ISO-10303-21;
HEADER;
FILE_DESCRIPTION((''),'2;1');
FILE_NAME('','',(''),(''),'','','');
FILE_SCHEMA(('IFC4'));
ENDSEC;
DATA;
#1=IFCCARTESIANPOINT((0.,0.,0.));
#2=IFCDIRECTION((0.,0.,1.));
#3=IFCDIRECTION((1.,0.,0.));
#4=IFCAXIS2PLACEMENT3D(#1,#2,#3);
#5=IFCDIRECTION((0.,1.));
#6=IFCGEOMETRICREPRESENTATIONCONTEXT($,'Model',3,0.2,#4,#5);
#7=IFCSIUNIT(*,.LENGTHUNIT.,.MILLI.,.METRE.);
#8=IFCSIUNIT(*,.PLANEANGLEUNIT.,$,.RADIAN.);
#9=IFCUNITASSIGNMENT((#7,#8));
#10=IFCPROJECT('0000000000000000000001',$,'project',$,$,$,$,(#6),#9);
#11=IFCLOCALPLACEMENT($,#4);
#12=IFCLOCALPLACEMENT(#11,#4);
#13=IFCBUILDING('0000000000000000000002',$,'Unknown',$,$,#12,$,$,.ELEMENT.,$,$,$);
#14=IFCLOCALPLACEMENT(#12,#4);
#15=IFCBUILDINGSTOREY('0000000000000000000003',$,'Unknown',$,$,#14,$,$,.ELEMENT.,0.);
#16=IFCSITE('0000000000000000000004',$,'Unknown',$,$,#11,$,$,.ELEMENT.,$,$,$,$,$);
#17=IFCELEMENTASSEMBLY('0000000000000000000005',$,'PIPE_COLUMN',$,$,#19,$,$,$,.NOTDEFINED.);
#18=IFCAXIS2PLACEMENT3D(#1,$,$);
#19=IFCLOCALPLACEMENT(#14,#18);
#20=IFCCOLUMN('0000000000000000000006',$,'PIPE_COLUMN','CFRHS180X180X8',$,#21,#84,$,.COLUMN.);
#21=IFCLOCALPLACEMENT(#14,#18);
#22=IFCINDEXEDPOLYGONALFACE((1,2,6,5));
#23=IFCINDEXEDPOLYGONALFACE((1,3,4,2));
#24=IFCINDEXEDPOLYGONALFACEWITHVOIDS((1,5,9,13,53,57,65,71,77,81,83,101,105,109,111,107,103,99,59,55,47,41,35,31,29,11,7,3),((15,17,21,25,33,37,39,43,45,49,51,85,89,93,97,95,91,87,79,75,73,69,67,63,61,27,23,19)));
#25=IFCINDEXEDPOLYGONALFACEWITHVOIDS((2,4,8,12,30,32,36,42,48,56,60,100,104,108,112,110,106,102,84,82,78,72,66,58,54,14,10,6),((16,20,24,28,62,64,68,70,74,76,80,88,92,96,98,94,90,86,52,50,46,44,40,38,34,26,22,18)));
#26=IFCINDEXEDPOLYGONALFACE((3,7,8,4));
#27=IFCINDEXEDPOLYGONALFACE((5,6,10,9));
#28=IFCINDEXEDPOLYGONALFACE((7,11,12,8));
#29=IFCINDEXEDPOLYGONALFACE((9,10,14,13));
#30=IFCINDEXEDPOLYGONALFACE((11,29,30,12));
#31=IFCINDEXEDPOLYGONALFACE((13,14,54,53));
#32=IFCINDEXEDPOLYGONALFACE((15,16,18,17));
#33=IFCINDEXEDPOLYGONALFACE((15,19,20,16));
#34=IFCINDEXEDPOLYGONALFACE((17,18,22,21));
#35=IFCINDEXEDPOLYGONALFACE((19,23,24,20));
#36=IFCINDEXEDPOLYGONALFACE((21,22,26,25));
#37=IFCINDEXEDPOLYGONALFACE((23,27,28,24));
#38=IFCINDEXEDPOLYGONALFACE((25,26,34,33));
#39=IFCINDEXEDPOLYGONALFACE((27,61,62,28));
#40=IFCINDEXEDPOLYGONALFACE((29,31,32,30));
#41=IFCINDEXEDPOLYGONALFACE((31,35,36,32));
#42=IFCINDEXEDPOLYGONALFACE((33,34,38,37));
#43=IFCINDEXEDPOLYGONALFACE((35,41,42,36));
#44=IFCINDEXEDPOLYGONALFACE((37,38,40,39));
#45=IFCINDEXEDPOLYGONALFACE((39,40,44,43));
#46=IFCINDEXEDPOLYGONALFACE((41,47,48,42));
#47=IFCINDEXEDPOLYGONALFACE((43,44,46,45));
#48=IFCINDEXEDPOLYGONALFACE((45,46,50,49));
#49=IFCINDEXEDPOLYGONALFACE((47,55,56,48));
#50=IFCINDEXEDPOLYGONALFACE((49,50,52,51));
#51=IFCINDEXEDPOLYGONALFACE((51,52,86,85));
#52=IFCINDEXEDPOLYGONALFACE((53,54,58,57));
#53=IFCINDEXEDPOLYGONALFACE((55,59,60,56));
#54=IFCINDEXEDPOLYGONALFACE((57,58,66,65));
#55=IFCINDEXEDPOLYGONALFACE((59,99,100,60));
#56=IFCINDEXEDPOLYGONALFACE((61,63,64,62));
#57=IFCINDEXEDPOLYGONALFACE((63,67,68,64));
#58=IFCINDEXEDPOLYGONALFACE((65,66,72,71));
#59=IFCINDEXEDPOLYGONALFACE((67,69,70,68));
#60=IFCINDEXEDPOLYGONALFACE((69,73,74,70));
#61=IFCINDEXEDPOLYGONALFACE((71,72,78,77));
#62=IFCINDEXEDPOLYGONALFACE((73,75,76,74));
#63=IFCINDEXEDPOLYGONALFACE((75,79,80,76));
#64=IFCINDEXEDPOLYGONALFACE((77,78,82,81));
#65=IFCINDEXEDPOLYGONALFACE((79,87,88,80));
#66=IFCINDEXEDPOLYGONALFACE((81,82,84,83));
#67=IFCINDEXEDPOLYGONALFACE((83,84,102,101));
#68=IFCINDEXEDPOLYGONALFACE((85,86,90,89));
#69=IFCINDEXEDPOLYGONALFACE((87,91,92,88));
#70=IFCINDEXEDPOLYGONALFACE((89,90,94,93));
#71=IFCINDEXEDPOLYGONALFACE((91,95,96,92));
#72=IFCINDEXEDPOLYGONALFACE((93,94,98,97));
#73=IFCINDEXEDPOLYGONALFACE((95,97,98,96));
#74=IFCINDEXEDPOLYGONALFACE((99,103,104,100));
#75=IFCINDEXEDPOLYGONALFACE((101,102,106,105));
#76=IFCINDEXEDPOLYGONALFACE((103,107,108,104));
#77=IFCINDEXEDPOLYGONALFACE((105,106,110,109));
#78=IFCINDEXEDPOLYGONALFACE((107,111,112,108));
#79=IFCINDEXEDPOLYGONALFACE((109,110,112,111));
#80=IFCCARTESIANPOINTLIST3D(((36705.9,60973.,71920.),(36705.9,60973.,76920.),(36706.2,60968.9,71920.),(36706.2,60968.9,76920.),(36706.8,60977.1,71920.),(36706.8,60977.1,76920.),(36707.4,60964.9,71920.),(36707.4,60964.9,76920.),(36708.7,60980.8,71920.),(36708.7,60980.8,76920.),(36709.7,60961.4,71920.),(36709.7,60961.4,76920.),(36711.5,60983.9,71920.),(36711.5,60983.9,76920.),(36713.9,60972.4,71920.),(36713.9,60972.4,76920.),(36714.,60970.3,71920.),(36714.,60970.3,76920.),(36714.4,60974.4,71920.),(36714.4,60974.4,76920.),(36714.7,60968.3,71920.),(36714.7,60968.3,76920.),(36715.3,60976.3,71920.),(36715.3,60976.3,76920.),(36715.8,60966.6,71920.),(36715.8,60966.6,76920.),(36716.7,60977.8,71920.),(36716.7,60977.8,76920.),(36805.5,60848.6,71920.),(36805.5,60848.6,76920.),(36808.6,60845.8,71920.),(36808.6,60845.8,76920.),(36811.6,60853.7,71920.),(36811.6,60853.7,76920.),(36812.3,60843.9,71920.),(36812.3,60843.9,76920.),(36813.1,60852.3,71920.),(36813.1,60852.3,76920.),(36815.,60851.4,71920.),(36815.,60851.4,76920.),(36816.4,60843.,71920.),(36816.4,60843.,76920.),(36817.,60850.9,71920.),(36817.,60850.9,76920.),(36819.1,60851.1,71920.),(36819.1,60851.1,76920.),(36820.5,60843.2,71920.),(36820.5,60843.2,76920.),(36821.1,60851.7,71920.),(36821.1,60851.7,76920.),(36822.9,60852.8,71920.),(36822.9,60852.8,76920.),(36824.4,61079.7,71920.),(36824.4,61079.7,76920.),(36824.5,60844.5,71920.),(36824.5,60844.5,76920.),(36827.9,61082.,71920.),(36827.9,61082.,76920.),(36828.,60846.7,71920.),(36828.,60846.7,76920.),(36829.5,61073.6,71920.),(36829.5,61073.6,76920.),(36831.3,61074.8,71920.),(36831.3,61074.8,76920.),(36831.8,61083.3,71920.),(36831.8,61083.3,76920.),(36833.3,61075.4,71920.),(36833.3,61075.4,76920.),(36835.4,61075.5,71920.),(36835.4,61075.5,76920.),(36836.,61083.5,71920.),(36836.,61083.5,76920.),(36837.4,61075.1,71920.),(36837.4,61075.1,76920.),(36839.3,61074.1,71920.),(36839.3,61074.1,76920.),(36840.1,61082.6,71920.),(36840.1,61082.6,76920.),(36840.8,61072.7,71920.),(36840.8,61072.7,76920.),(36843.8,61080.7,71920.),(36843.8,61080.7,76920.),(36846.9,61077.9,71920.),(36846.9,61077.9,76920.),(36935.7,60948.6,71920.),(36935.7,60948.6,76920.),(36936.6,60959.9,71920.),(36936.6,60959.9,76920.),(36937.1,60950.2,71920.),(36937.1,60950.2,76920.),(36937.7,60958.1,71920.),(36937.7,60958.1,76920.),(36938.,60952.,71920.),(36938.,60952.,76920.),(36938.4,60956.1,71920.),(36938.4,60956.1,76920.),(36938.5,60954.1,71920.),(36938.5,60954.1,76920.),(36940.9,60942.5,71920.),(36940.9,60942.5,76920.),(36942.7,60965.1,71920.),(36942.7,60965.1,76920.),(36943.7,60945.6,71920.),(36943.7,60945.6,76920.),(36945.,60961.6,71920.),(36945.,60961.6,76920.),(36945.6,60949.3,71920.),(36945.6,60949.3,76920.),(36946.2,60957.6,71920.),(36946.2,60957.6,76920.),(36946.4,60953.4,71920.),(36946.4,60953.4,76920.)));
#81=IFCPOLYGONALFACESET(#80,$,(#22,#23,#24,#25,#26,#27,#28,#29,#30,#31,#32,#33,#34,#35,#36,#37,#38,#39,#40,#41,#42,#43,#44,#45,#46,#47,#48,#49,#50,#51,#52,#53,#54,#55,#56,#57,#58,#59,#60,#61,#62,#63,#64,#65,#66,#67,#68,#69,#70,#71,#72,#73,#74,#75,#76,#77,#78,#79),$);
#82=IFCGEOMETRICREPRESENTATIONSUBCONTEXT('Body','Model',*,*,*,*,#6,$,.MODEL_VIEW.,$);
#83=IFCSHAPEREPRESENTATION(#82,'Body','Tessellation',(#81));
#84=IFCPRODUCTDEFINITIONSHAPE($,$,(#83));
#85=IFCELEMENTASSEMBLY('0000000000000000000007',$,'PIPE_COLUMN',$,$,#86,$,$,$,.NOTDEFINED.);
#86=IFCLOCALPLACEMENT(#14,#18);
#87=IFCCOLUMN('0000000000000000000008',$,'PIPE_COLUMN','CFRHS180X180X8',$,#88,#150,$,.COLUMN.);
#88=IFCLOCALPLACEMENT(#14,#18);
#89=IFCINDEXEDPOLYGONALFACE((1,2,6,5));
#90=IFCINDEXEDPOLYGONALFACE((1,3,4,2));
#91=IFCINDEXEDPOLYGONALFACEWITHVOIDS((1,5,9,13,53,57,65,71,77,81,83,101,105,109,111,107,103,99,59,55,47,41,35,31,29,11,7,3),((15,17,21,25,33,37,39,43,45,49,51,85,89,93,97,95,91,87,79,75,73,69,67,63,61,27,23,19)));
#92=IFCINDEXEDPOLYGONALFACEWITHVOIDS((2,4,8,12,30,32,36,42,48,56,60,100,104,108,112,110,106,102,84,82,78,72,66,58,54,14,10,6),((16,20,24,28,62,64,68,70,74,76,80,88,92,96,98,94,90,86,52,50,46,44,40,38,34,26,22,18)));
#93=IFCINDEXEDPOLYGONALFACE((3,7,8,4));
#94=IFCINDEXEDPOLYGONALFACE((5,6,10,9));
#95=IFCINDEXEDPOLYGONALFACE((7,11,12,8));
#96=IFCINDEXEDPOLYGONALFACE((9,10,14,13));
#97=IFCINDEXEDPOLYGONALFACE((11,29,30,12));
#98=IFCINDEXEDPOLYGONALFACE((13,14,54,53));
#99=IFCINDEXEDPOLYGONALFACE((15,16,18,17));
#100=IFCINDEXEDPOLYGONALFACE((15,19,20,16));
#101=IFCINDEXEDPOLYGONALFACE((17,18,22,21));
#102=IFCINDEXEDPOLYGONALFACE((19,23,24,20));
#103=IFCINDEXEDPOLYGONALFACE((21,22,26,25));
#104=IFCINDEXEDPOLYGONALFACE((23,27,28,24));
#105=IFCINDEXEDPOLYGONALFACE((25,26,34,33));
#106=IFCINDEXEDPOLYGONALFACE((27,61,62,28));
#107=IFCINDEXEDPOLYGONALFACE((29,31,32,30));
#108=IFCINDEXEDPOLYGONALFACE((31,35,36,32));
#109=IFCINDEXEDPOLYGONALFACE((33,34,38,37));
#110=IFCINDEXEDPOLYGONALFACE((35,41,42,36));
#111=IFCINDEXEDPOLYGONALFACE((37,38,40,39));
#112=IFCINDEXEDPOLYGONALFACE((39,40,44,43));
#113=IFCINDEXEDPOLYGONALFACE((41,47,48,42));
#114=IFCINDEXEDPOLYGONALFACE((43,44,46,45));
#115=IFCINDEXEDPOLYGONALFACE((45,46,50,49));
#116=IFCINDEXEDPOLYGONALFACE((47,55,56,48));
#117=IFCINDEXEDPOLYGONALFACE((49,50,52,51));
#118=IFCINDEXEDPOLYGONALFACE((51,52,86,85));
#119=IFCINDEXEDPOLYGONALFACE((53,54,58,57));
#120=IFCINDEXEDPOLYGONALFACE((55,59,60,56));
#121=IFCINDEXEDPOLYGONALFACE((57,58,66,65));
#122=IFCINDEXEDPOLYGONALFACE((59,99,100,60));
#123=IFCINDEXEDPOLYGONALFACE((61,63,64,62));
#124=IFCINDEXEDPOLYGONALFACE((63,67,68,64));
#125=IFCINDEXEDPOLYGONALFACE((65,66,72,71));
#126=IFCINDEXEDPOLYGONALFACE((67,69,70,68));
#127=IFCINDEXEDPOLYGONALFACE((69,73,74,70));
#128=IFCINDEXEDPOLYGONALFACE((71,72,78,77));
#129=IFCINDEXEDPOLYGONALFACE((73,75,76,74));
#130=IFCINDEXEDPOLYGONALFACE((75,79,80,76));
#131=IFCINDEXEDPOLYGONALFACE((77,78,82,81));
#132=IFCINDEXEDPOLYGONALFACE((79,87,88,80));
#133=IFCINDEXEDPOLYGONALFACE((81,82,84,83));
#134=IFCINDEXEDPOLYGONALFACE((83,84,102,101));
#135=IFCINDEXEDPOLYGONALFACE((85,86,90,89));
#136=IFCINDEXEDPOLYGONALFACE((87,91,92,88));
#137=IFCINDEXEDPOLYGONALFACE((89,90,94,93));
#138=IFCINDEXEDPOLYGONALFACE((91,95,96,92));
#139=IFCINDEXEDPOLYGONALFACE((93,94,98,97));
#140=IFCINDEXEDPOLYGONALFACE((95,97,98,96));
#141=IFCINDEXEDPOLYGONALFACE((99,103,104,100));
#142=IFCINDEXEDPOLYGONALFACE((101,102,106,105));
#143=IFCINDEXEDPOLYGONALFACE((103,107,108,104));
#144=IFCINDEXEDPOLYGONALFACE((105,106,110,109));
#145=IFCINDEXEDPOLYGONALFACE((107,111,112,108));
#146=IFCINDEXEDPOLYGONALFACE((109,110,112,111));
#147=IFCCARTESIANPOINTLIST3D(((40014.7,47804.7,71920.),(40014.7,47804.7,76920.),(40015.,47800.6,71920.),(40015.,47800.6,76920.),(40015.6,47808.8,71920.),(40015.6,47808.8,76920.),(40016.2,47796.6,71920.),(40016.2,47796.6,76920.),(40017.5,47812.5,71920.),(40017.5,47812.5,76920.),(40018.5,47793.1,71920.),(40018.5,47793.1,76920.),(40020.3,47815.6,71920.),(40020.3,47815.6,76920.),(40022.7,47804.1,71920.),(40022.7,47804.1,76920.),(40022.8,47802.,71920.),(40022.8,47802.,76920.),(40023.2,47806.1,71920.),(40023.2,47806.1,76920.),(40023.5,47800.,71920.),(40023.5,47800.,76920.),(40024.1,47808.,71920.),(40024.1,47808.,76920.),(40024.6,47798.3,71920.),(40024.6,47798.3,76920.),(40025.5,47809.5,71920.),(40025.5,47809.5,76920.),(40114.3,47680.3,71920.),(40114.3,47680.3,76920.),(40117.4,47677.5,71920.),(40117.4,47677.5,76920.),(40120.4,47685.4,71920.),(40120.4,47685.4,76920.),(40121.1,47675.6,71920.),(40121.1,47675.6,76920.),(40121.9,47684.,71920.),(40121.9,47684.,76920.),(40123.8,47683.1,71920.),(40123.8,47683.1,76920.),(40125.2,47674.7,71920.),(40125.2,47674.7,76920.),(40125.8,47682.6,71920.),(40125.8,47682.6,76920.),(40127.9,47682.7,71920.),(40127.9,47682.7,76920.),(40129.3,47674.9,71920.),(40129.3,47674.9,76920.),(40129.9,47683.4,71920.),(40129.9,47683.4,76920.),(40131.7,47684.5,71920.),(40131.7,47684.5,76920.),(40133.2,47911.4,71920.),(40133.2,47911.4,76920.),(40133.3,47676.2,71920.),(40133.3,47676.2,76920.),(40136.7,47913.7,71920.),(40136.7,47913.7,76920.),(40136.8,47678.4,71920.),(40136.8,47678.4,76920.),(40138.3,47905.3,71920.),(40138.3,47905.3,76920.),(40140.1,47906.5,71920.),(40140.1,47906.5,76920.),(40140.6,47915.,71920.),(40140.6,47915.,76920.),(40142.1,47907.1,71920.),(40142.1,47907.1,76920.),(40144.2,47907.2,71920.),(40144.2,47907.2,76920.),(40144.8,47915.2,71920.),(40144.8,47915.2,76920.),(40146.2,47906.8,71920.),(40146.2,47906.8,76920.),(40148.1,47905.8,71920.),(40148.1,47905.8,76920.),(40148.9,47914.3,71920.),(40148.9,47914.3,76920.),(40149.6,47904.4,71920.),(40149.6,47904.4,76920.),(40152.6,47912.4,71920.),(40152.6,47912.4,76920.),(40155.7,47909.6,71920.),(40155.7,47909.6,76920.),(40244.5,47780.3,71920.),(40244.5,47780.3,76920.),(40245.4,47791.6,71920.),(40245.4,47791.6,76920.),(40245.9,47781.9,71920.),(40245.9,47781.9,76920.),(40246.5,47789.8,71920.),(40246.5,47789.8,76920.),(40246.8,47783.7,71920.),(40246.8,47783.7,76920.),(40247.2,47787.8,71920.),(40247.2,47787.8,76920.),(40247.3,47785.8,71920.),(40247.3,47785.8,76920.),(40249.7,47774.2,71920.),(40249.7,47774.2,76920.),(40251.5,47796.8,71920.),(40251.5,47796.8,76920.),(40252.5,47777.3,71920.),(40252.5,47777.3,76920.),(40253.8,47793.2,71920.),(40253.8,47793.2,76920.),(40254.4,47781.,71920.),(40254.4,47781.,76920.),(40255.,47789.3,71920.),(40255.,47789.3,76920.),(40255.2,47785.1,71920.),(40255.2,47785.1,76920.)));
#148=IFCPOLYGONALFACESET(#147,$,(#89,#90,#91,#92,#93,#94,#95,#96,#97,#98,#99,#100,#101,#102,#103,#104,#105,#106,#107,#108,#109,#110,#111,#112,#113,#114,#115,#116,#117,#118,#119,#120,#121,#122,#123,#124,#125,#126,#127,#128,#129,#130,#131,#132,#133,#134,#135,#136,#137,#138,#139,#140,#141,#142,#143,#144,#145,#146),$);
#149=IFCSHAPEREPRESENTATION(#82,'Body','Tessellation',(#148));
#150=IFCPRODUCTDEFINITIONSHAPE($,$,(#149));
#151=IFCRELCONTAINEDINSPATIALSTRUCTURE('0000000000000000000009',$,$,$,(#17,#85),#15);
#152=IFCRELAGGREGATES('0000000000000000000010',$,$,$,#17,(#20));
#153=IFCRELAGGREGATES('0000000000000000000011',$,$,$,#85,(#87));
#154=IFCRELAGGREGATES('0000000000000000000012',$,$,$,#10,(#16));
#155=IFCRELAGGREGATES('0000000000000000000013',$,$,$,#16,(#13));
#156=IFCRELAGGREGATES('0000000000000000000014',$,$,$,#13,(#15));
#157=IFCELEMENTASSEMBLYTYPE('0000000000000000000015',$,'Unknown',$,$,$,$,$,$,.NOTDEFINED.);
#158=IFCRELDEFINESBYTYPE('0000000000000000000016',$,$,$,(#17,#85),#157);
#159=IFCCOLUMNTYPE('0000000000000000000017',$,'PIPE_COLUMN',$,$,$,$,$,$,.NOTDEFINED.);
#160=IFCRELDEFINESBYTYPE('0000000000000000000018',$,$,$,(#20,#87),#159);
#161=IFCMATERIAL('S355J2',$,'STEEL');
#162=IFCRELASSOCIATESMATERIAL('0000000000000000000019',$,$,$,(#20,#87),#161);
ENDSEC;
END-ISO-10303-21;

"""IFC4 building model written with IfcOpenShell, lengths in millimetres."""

from ifc_helpers import new_model, si_unit, direction, frame, origin_with_axes, origin_2d_with_axis, place, context, subcontext, project, spatial, hollow_rectangle, extrude, material, material_profile, profile_set, profile_usage, type_object, element, aggregate, save


model = new_model("IFC4")

# Units and contexts
model_context = context("Model", 3, precision=0.2, world=origin_with_axes(), true_north=direction((0.0, 1.0)))
body_context = subcontext(model_context, "Body", "Model", "MODEL_VIEW")
ifc_project = project(units=[si_unit("LENGTHUNIT", "METRE", prefix="MILLI"), si_unit("PLANEANGLEUNIT", "RADIAN")], contexts=[model_context])

# Site, building, storey
site_placement = place(None, origin_with_axes())
site = spatial("IfcSite", under=ifc_project, at=site_placement, Name="Unknown", CompositionType="ELEMENT")
building_placement = place(site_placement, origin_with_axes())
building = spatial("IfcBuilding", under=site, at=building_placement, Name="Unknown", CompositionType="ELEMENT")
storey_placement = place(building_placement, origin_with_axes())
storey = spatial("IfcBuildingStorey", under=building, at=storey_placement, Name="Unknown", CompositionType="ELEMENT", Elevation=0.0)

# Element assemblies, columns
element_assembly_type = type_object("IfcElementAssemblyType", Name="Unknown", PredefinedType="NOTDEFINED")
ifc_material_1 = material(Name="S355J2", Category="STEEL")
ifc_material_profile_1 = material_profile(ifc_material_1, hollow_rectangle(XDim=180.0, YDim=180.0, WallThickness=8.0, InnerFilletRadius=8.0, OuterFilletRadius=16.0, at=origin_2d_with_axis()), Name="CFRHS180X180X8")
ifc_profile_set_1 = profile_set([ifc_material_profile_1])
ifc_profile_usage_1 = profile_usage(ifc_profile_set_1, cardinal=6)
column_type_1 = type_object("IfcColumnType", Name="PIPE_COLUMN")
assembly_1_placement = place(storey_placement, frame((36826.2, 60963.2, 71920.0), z_axis=(-0.762329, -0.64719, 0.0), x_axis=(0.0, 0.0, 1.0)))
assembly_1 = element("IfcElementAssembly", 1, at=assembly_1_placement, inside=storey, type_object=element_assembly_type, Name="PIPE_COLUMN", PredefinedType="NOTDEFINED")
column_1_placement = place(assembly_1_placement, origin_with_axes())
column_1 = element("IfcColumn", 2, at=column_1_placement, type_object=column_type_1, material=ifc_profile_usage_1, Name="PIPE_COLUMN", Description="CFRHS180X180X8", PredefinedType="COLUMN", context=body_context, shape_type="SolidModel", body=[
    extrude(hollow_rectangle(XDim=180.0, YDim=180.0, WallThickness=8.0, InnerFilletRadius=8.0, OuterFilletRadius=16.0, at=origin_2d_with_axis()), frame((0.0, 0.0, 0.0), z_axis=(-1.0, 0.0, 0.0), x_axis=(0.0, 0.0, 1.0)), (0.0, 0.0, -1.0), 5000.0),
])
aggregate(assembly_1, [column_1])
assembly_2_placement = place(storey_placement, frame((40135.0, 47794.9, 71920.0), z_axis=(-0.762329, -0.64719, 0.0), x_axis=(0.0, 0.0, 1.0)))
assembly_2 = element("IfcElementAssembly", 3, at=assembly_2_placement, inside=storey, type_object=element_assembly_type, Name="PIPE_COLUMN", PredefinedType="NOTDEFINED")
ifc_profile_usage_2 = profile_usage(ifc_profile_set_1, cardinal=4)
column_2_placement = place(assembly_2_placement, origin_with_axes())
column_2 = element("IfcColumn", 4, at=column_2_placement, type_object=column_type_1, material=ifc_profile_usage_2, Name="PIPE_COLUMN", Description="CFRHS180X180X8", PredefinedType="COLUMN", context=body_context, shape_type="SolidModel", body=[
    extrude(hollow_rectangle(XDim=180.0, YDim=180.0, WallThickness=8.0, InnerFilletRadius=8.0, OuterFilletRadius=16.0, at=origin_2d_with_axis()), frame((0.0, 0.0, 0.0), z_axis=(-1.0, 0.0, 0.0), x_axis=(0.0, 0.0, 1.0)), (0.0, 0.0, -1.0), 5000.0),
])
aggregate(assembly_2, [column_2])

save(model, "model.ifc")
